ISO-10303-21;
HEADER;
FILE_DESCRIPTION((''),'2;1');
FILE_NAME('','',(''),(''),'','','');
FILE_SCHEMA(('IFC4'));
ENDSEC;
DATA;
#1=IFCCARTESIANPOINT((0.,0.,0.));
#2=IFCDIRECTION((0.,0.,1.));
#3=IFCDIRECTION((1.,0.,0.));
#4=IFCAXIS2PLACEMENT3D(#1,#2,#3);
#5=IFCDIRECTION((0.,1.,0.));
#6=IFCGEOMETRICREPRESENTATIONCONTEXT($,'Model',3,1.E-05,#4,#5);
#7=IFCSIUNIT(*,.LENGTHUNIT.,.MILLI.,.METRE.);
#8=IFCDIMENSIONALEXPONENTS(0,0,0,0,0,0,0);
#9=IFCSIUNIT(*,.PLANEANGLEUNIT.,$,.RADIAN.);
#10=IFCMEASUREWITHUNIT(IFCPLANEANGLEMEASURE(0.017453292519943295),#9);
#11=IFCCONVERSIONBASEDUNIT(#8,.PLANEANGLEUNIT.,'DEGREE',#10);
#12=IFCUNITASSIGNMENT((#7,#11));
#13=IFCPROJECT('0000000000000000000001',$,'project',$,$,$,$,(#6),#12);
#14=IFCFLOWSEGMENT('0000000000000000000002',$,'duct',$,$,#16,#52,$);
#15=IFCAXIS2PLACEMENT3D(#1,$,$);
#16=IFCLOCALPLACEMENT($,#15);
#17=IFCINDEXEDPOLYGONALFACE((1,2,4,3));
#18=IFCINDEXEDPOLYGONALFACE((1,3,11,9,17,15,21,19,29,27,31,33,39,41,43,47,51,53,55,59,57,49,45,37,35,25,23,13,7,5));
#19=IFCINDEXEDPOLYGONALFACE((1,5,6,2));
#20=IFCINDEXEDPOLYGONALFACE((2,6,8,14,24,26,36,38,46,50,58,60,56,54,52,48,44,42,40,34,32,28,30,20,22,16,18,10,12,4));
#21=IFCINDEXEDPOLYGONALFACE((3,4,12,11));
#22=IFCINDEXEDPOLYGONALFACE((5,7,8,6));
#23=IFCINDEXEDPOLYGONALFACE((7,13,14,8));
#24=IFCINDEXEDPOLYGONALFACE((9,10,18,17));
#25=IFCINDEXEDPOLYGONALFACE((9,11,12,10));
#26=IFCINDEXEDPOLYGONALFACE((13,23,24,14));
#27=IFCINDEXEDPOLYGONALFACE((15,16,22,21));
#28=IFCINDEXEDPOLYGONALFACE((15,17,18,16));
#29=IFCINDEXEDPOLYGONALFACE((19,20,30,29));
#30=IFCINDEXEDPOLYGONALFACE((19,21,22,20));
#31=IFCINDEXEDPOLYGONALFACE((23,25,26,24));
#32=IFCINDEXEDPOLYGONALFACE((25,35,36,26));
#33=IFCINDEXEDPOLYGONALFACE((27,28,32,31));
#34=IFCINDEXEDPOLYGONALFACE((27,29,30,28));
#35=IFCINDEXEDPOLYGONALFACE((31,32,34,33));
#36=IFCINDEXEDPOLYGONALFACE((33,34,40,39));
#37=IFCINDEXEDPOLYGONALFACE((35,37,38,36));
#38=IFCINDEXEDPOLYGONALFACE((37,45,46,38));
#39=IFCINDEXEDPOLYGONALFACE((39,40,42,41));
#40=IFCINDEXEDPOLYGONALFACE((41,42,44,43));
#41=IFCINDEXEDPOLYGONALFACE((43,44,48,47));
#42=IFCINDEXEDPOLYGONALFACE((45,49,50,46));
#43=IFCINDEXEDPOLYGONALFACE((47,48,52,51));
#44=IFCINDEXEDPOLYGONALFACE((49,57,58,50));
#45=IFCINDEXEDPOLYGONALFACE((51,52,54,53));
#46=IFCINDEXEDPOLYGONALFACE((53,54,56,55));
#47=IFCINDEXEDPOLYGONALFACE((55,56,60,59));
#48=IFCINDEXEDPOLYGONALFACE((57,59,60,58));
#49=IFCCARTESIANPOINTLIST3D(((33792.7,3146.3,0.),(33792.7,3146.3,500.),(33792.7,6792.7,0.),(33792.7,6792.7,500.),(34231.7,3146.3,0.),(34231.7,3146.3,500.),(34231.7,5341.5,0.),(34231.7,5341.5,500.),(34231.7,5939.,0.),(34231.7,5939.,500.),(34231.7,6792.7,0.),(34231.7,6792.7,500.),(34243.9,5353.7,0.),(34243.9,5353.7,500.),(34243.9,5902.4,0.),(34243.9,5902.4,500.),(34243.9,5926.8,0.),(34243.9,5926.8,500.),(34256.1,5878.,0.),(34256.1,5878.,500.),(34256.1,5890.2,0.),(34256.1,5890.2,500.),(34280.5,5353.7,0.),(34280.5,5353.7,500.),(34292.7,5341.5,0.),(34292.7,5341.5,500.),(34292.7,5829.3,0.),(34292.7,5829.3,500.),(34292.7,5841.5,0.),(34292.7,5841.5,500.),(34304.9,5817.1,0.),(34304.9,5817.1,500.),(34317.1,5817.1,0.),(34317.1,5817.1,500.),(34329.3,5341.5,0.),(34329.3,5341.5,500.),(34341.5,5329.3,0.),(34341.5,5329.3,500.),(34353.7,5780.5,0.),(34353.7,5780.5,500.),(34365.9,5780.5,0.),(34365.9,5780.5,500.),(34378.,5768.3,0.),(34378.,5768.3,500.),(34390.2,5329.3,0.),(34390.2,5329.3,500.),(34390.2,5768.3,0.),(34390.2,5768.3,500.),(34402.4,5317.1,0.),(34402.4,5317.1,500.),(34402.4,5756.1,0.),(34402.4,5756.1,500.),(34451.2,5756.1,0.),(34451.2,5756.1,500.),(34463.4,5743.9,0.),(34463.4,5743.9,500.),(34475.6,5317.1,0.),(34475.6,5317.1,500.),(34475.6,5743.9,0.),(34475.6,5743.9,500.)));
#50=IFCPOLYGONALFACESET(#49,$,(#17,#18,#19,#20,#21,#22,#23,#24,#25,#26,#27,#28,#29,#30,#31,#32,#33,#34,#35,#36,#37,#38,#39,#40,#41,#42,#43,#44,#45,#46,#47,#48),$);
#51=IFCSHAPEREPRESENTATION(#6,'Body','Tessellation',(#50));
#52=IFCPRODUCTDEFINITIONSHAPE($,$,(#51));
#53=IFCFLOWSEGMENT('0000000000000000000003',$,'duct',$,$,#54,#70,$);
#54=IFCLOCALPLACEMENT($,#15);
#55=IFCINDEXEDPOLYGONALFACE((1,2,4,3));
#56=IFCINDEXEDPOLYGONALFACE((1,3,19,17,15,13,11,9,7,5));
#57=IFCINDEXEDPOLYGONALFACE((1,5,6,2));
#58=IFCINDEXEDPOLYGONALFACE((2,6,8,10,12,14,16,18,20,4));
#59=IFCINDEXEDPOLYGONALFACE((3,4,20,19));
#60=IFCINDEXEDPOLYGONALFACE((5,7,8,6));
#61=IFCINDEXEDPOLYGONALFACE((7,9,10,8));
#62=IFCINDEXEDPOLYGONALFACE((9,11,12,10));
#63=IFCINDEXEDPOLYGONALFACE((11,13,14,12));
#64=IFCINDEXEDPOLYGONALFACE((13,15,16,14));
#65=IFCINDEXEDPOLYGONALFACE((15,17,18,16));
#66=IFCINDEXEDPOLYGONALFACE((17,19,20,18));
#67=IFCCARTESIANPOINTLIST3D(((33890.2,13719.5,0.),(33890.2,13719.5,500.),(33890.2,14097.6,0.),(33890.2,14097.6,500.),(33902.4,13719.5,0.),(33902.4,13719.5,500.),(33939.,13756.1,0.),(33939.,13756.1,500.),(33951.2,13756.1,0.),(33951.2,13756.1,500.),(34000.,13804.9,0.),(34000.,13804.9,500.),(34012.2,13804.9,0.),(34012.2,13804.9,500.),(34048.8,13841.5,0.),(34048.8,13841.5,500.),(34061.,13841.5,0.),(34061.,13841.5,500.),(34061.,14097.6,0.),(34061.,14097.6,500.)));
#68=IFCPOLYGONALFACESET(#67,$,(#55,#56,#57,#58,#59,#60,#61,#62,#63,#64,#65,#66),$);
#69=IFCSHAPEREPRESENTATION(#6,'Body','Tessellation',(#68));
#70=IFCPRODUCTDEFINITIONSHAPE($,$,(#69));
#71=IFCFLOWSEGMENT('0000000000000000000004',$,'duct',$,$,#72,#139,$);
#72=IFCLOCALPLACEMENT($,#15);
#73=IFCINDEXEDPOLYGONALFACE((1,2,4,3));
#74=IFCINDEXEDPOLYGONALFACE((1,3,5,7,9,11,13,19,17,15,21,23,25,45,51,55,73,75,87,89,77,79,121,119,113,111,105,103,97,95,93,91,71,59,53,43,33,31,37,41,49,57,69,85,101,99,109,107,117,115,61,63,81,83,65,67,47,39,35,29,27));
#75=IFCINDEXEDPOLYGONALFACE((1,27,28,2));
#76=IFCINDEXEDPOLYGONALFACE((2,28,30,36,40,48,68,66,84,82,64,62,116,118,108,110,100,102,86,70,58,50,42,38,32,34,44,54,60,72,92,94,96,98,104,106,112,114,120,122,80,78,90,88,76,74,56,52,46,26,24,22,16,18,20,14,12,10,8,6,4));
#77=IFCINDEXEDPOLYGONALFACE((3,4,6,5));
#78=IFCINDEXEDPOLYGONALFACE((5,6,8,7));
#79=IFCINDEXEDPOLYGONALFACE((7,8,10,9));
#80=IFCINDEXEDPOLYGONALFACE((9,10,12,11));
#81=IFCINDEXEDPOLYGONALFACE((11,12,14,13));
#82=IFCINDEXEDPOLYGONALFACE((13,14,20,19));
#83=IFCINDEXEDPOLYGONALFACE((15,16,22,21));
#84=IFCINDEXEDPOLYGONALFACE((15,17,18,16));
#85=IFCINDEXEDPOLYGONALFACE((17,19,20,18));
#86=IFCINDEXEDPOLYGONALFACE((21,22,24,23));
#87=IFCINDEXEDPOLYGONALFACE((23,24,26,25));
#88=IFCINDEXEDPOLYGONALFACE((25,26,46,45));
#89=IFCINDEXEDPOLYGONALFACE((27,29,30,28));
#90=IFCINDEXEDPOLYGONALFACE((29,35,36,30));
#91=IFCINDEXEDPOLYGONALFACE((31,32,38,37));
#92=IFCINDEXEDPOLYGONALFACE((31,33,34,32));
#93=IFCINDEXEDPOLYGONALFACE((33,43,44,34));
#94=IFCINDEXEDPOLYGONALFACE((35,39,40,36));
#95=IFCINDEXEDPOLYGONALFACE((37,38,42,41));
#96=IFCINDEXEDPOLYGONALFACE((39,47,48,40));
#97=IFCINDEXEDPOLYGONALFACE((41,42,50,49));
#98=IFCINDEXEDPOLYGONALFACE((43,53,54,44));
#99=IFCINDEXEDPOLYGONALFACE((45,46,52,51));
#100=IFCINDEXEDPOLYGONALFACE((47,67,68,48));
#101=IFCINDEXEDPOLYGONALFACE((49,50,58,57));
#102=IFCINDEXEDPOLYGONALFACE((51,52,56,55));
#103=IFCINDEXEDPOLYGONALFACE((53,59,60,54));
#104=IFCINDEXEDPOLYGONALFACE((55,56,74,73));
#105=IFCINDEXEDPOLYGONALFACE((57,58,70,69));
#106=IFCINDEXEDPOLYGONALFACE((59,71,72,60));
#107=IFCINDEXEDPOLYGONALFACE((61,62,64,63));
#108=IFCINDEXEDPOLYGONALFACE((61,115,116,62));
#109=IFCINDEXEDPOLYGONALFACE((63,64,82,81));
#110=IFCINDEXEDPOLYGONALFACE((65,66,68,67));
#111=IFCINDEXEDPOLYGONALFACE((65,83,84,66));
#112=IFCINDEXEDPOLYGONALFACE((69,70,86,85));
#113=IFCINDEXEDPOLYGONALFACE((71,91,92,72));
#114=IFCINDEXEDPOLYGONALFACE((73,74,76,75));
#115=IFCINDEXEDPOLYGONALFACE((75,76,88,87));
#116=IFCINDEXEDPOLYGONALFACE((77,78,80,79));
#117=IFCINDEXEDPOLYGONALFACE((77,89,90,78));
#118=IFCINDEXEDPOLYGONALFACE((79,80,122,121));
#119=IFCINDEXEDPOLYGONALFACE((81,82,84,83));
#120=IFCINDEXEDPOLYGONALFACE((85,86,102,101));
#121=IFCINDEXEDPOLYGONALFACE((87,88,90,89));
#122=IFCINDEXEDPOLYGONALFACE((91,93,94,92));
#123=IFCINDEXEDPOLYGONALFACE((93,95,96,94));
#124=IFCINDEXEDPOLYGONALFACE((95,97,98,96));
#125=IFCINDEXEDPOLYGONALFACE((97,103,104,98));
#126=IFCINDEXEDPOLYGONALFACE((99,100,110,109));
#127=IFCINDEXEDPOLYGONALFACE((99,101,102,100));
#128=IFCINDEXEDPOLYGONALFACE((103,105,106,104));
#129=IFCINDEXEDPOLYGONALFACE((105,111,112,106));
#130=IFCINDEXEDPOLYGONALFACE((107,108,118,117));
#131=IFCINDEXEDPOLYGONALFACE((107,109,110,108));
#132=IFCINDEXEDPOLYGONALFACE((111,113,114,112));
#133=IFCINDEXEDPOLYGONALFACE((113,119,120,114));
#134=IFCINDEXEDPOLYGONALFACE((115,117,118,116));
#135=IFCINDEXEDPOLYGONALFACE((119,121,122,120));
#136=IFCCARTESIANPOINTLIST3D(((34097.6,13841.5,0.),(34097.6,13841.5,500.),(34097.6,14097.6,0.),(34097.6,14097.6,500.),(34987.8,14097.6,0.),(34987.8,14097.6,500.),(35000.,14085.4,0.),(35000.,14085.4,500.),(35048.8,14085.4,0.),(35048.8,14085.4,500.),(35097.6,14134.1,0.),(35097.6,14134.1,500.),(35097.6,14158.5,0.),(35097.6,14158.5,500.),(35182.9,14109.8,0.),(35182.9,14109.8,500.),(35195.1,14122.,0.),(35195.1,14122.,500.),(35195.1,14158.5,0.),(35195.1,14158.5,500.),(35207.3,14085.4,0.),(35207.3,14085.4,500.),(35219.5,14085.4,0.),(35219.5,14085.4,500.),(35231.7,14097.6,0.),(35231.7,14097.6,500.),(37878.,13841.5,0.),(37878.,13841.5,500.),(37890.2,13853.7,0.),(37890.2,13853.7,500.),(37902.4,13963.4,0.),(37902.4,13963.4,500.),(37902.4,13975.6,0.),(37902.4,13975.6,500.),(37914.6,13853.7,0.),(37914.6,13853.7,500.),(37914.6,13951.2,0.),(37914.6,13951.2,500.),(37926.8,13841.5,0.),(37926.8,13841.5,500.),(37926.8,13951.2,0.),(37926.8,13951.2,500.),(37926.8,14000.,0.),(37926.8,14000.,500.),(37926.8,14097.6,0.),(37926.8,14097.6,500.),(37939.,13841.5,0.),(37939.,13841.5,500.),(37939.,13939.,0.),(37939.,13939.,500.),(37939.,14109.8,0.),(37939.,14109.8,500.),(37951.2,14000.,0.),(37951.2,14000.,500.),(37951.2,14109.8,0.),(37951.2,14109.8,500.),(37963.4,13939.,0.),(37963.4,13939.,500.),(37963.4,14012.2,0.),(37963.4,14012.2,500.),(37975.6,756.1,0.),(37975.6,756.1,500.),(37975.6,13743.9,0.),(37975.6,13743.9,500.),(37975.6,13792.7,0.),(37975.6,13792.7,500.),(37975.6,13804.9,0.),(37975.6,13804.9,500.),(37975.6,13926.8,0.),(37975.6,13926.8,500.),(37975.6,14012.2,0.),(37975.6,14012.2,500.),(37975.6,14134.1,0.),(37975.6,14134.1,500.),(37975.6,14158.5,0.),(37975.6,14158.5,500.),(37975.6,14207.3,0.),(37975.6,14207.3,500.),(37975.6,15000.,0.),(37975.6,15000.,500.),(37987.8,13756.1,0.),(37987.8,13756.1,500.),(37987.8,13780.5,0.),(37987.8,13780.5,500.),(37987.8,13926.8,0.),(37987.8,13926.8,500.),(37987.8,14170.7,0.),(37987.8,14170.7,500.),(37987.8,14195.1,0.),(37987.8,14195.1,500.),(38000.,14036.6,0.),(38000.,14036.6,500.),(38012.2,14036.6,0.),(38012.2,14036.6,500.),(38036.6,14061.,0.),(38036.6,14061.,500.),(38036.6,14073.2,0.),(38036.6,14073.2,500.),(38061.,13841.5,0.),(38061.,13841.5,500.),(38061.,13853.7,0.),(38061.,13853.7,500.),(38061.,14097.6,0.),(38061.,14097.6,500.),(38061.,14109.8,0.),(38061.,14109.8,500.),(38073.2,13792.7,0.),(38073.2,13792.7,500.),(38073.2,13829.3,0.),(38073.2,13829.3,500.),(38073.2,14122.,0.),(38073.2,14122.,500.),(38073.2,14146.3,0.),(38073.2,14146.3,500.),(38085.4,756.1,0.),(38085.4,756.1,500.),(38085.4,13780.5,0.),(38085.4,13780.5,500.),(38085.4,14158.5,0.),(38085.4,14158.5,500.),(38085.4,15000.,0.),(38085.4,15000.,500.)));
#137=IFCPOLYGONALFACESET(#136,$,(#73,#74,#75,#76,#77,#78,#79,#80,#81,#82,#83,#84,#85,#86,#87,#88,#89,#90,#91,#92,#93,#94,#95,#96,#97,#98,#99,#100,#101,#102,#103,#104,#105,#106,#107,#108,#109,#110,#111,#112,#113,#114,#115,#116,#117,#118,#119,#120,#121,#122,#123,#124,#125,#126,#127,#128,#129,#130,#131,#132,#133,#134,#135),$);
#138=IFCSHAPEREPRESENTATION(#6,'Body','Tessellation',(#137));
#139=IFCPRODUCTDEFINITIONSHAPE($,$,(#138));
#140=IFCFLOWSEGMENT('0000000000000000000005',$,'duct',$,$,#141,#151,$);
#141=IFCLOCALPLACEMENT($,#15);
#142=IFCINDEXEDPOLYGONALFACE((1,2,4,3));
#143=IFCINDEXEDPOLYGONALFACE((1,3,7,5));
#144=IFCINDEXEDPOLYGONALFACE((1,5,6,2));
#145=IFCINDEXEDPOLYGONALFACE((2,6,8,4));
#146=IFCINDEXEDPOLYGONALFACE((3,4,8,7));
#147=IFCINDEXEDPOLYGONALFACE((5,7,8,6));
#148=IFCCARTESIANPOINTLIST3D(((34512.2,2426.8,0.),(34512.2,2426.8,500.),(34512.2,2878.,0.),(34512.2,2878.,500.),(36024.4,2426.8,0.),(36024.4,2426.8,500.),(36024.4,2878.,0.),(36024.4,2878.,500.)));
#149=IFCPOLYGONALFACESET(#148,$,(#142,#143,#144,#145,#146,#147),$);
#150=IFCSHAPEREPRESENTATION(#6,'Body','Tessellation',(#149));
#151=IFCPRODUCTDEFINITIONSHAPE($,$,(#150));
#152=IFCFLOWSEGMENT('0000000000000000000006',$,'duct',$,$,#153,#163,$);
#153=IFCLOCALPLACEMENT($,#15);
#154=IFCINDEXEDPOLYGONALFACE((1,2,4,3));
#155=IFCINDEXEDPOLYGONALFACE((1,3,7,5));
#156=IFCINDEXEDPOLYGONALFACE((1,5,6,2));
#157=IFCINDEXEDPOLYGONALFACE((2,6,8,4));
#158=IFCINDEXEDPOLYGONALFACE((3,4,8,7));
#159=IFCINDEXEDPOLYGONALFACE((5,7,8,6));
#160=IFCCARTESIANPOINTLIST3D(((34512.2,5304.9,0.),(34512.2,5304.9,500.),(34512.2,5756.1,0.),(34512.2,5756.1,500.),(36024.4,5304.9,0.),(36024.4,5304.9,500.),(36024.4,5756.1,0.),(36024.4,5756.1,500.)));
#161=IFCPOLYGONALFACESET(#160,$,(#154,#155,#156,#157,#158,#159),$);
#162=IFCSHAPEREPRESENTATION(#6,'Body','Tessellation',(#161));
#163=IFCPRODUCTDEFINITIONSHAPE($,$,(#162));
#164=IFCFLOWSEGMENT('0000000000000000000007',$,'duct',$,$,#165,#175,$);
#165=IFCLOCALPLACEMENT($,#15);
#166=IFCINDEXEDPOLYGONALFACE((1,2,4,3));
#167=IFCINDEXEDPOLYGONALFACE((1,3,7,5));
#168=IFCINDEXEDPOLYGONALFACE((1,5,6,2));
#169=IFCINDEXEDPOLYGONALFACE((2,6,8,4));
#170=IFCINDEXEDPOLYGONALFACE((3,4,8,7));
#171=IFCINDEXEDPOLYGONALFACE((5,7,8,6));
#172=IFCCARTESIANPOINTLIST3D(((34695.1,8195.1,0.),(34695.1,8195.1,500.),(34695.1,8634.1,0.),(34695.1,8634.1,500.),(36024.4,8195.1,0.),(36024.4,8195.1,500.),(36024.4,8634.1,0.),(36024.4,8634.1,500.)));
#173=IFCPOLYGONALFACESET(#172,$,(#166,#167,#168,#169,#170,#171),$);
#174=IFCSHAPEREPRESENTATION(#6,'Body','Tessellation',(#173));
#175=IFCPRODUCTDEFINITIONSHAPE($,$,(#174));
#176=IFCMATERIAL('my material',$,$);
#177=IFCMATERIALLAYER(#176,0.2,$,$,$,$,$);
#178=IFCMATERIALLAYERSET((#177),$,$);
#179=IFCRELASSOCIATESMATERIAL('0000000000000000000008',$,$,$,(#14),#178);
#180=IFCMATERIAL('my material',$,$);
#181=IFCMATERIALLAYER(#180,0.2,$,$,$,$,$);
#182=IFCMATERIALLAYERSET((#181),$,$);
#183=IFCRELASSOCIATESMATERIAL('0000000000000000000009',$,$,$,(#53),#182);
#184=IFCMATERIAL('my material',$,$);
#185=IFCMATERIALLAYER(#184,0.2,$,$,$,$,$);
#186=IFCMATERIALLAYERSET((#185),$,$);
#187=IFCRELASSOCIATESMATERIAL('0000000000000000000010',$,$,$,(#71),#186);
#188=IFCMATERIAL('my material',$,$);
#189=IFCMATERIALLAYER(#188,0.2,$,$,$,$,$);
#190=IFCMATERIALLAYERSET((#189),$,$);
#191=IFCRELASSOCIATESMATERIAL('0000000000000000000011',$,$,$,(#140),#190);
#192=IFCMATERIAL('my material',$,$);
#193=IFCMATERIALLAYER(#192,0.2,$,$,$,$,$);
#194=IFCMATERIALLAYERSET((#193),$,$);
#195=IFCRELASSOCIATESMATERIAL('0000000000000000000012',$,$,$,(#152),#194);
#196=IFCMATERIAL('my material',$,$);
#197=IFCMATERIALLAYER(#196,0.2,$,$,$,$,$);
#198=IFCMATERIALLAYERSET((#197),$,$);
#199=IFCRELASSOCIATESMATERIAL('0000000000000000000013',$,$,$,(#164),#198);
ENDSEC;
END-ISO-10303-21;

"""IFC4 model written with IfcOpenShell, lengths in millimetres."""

from ifc_helpers import new_model, entity, si_unit, converted_unit, direction, origin_with_axes, place, context, project, polyline, outline, extrude, material, layer, layer_set, layer_usage, element, save


model = new_model("IFC4")

# Units and contexts
model_context = context("Model", 3, precision=1e-05, world=origin_with_axes(), true_north=direction((0.0, 1.0, 0.0)))
ifc_project = project(units=[si_unit("LENGTHUNIT", "METRE", prefix="MILLI"), converted_unit("PLANEANGLEUNIT", "DEGREE", entity("IfcPlaneAngleMeasure", 0.017453292519943295), si_unit("PLANEANGLEUNIT", "RADIAN"), dimensions=[0, 0, 0, 0, 0, 0, 0])], contexts=[model_context])

# Flow segments
ifc_material_1 = material(Name="my material")
ifc_layer_1 = layer(ifc_material_1, 0.2)
ifc_layer_set_1 = layer_set([ifc_layer_1])
ifc_layer_usage_1 = layer_usage(ifc_layer_set_1, "AXIS2", "POSITIVE", -0.1)
flow_segment_1_placement = place(None, origin_with_axes())
element("IfcFlowSegment", 1, at=flow_segment_1_placement, material=ifc_layer_usage_1, Name="duct", context=model_context, shape_type="SweptSolid", body=[
    extrude(outline(polyline([(33792.7, 3146.3), (34231.7, 3146.3), (34231.7, 5341.5), (34243.9, 5353.7), (34280.5, 5353.7), (34292.7, 5341.5), (34329.3, 5341.5), (34341.5, 5329.3), (34390.2, 5329.3), (34402.4, 5317.1), (34475.6, 5317.1), (34475.6, 5743.9), (34463.4, 5743.9), (34451.2, 5756.1), (34402.4, 5756.1), (34390.2, 5768.3), (34378.0, 5768.3), (34365.9, 5780.5), (34353.7, 5780.5), (34317.1, 5817.1), (34304.9, 5817.1), (34292.7, 5829.3), (34292.7, 5841.5), (34256.1, 5878.0), (34256.1, 5890.2), (34243.9, 5902.4), (34243.9, 5926.8), (34231.7, 5939.0), (34231.7, 6792.7), (33792.7, 6792.7), (33792.7, 3146.3)])), origin_with_axes(), (0.0, 0.0, 1.0), 500.0),
])
ifc_material_2 = material(Name="my material")
ifc_layer_2 = layer(ifc_material_2, 0.2)
ifc_layer_set_2 = layer_set([ifc_layer_2])
ifc_layer_usage_2 = layer_usage(ifc_layer_set_2, "AXIS2", "POSITIVE", -0.1)
flow_segment_2_placement = place(None, origin_with_axes())
element("IfcFlowSegment", 2, at=flow_segment_2_placement, material=ifc_layer_usage_2, Name="duct", context=model_context, shape_type="SweptSolid", body=[
    extrude(outline(polyline([(33890.2, 13719.5), (33902.4, 13719.5), (33939.0, 13756.1), (33951.2, 13756.1), (34000.0, 13804.9), (34012.2, 13804.9), (34048.8, 13841.5), (34061.0, 13841.5), (34061.0, 14097.6), (33890.2, 14097.6), (33890.2, 13719.5)])), origin_with_axes(), (0.0, 0.0, 1.0), 500.0),
])
ifc_material_3 = material(Name="my material")
ifc_layer_3 = layer(ifc_material_3, 0.2)
ifc_layer_set_3 = layer_set([ifc_layer_3])
ifc_layer_usage_3 = layer_usage(ifc_layer_set_3, "AXIS2", "POSITIVE", -0.1)
flow_segment_3_placement = place(None, origin_with_axes())
element("IfcFlowSegment", 3, at=flow_segment_3_placement, material=ifc_layer_usage_3, Name="duct", context=model_context, shape_type="SweptSolid", body=[
    extrude(outline(polyline([(34097.6, 13841.5), (37878.0, 13841.5), (37890.2, 13853.7), (37914.6, 13853.7), (37926.8, 13841.5), (37939.0, 13841.5), (37975.6, 13804.9), (37975.6, 13792.7), (37987.8, 13780.5), (37987.8, 13756.1), (37975.6, 13743.9), (37975.6, 756.1), (38085.4, 756.1), (38085.4, 13780.5), (38073.2, 13792.7), (38073.2, 13829.3), (38061.0, 13841.5), (38061.0, 13853.7), (37987.8, 13926.8), (37975.6, 13926.8), (37963.4, 13939.0), (37939.0, 13939.0), (37926.8, 13951.2), (37914.6, 13951.2), (37902.4, 13963.4), (37902.4, 13975.6), (37926.8, 14000.0), (37951.2, 14000.0), (37963.4, 14012.2), (37975.6, 14012.2), (38000.0, 14036.6), (38012.2, 14036.6), (38036.6, 14061.0), (38036.6, 14073.2), (38061.0, 14097.6), (38061.0, 14109.8), (38073.2, 14122.0), (38073.2, 14146.3), (38085.4, 14158.5), (38085.4, 15000.0), (37975.6, 15000.0), (37975.6, 14207.3), (37987.8, 14195.1), (37987.8, 14170.7), (37975.6, 14158.5), (37975.6, 14134.1), (37951.2, 14109.8), (37939.0, 14109.8), (37926.8, 14097.6), (35231.7, 14097.6), (35219.5, 14085.4), (35207.3, 14085.4), (35182.9, 14109.8), (35195.1, 14122.0), (35195.1, 14158.5), (35097.6, 14158.5), (35097.6, 14134.1), (35048.8, 14085.4), (35000.0, 14085.4), (34987.8, 14097.6), (34097.6, 14097.6), (34097.6, 13841.5)])), origin_with_axes(), (0.0, 0.0, 1.0), 500.0),
])
ifc_material_4 = material(Name="my material")
ifc_layer_4 = layer(ifc_material_4, 0.2)
ifc_layer_set_4 = layer_set([ifc_layer_4])
ifc_layer_usage_4 = layer_usage(ifc_layer_set_4, "AXIS2", "POSITIVE", -0.1)
flow_segment_4_placement = place(None, origin_with_axes())
element("IfcFlowSegment", 4, at=flow_segment_4_placement, material=ifc_layer_usage_4, Name="duct", context=model_context, shape_type="SweptSolid", body=[
    extrude(outline(polyline([(34512.2, 2426.8), (36024.4, 2426.8), (36024.4, 2878.0), (34512.2, 2878.0), (34512.2, 2426.8)])), origin_with_axes(), (0.0, 0.0, 1.0), 500.0),
])
ifc_material_5 = material(Name="my material")
ifc_layer_5 = layer(ifc_material_5, 0.2)
ifc_layer_set_5 = layer_set([ifc_layer_5])
ifc_layer_usage_5 = layer_usage(ifc_layer_set_5, "AXIS2", "POSITIVE", -0.1)
flow_segment_5_placement = place(None, origin_with_axes())
element("IfcFlowSegment", 5, at=flow_segment_5_placement, material=ifc_layer_usage_5, Name="duct", context=model_context, shape_type="SweptSolid", body=[
    extrude(outline(polyline([(34512.2, 5304.9), (36024.4, 5304.9), (36024.4, 5756.1), (34512.2, 5756.1), (34512.2, 5304.9)])), origin_with_axes(), (0.0, 0.0, 1.0), 500.0),
])
ifc_material_6 = material(Name="my material")
ifc_layer_6 = layer(ifc_material_6, 0.2)
ifc_layer_set_6 = layer_set([ifc_layer_6])
ifc_layer_usage_6 = layer_usage(ifc_layer_set_6, "AXIS2", "POSITIVE", -0.1)
flow_segment_6_placement = place(None, origin_with_axes())
element("IfcFlowSegment", 6, at=flow_segment_6_placement, material=ifc_layer_usage_6, Name="duct", context=model_context, shape_type="SweptSolid", body=[
    extrude(outline(polyline([(34695.1, 8195.1), (36024.4, 8195.1), (36024.4, 8634.1), (34695.1, 8634.1), (34695.1, 8195.1)])), origin_with_axes(), (0.0, 0.0, 1.0), 500.0),
])

save(model, "model.ifc")
